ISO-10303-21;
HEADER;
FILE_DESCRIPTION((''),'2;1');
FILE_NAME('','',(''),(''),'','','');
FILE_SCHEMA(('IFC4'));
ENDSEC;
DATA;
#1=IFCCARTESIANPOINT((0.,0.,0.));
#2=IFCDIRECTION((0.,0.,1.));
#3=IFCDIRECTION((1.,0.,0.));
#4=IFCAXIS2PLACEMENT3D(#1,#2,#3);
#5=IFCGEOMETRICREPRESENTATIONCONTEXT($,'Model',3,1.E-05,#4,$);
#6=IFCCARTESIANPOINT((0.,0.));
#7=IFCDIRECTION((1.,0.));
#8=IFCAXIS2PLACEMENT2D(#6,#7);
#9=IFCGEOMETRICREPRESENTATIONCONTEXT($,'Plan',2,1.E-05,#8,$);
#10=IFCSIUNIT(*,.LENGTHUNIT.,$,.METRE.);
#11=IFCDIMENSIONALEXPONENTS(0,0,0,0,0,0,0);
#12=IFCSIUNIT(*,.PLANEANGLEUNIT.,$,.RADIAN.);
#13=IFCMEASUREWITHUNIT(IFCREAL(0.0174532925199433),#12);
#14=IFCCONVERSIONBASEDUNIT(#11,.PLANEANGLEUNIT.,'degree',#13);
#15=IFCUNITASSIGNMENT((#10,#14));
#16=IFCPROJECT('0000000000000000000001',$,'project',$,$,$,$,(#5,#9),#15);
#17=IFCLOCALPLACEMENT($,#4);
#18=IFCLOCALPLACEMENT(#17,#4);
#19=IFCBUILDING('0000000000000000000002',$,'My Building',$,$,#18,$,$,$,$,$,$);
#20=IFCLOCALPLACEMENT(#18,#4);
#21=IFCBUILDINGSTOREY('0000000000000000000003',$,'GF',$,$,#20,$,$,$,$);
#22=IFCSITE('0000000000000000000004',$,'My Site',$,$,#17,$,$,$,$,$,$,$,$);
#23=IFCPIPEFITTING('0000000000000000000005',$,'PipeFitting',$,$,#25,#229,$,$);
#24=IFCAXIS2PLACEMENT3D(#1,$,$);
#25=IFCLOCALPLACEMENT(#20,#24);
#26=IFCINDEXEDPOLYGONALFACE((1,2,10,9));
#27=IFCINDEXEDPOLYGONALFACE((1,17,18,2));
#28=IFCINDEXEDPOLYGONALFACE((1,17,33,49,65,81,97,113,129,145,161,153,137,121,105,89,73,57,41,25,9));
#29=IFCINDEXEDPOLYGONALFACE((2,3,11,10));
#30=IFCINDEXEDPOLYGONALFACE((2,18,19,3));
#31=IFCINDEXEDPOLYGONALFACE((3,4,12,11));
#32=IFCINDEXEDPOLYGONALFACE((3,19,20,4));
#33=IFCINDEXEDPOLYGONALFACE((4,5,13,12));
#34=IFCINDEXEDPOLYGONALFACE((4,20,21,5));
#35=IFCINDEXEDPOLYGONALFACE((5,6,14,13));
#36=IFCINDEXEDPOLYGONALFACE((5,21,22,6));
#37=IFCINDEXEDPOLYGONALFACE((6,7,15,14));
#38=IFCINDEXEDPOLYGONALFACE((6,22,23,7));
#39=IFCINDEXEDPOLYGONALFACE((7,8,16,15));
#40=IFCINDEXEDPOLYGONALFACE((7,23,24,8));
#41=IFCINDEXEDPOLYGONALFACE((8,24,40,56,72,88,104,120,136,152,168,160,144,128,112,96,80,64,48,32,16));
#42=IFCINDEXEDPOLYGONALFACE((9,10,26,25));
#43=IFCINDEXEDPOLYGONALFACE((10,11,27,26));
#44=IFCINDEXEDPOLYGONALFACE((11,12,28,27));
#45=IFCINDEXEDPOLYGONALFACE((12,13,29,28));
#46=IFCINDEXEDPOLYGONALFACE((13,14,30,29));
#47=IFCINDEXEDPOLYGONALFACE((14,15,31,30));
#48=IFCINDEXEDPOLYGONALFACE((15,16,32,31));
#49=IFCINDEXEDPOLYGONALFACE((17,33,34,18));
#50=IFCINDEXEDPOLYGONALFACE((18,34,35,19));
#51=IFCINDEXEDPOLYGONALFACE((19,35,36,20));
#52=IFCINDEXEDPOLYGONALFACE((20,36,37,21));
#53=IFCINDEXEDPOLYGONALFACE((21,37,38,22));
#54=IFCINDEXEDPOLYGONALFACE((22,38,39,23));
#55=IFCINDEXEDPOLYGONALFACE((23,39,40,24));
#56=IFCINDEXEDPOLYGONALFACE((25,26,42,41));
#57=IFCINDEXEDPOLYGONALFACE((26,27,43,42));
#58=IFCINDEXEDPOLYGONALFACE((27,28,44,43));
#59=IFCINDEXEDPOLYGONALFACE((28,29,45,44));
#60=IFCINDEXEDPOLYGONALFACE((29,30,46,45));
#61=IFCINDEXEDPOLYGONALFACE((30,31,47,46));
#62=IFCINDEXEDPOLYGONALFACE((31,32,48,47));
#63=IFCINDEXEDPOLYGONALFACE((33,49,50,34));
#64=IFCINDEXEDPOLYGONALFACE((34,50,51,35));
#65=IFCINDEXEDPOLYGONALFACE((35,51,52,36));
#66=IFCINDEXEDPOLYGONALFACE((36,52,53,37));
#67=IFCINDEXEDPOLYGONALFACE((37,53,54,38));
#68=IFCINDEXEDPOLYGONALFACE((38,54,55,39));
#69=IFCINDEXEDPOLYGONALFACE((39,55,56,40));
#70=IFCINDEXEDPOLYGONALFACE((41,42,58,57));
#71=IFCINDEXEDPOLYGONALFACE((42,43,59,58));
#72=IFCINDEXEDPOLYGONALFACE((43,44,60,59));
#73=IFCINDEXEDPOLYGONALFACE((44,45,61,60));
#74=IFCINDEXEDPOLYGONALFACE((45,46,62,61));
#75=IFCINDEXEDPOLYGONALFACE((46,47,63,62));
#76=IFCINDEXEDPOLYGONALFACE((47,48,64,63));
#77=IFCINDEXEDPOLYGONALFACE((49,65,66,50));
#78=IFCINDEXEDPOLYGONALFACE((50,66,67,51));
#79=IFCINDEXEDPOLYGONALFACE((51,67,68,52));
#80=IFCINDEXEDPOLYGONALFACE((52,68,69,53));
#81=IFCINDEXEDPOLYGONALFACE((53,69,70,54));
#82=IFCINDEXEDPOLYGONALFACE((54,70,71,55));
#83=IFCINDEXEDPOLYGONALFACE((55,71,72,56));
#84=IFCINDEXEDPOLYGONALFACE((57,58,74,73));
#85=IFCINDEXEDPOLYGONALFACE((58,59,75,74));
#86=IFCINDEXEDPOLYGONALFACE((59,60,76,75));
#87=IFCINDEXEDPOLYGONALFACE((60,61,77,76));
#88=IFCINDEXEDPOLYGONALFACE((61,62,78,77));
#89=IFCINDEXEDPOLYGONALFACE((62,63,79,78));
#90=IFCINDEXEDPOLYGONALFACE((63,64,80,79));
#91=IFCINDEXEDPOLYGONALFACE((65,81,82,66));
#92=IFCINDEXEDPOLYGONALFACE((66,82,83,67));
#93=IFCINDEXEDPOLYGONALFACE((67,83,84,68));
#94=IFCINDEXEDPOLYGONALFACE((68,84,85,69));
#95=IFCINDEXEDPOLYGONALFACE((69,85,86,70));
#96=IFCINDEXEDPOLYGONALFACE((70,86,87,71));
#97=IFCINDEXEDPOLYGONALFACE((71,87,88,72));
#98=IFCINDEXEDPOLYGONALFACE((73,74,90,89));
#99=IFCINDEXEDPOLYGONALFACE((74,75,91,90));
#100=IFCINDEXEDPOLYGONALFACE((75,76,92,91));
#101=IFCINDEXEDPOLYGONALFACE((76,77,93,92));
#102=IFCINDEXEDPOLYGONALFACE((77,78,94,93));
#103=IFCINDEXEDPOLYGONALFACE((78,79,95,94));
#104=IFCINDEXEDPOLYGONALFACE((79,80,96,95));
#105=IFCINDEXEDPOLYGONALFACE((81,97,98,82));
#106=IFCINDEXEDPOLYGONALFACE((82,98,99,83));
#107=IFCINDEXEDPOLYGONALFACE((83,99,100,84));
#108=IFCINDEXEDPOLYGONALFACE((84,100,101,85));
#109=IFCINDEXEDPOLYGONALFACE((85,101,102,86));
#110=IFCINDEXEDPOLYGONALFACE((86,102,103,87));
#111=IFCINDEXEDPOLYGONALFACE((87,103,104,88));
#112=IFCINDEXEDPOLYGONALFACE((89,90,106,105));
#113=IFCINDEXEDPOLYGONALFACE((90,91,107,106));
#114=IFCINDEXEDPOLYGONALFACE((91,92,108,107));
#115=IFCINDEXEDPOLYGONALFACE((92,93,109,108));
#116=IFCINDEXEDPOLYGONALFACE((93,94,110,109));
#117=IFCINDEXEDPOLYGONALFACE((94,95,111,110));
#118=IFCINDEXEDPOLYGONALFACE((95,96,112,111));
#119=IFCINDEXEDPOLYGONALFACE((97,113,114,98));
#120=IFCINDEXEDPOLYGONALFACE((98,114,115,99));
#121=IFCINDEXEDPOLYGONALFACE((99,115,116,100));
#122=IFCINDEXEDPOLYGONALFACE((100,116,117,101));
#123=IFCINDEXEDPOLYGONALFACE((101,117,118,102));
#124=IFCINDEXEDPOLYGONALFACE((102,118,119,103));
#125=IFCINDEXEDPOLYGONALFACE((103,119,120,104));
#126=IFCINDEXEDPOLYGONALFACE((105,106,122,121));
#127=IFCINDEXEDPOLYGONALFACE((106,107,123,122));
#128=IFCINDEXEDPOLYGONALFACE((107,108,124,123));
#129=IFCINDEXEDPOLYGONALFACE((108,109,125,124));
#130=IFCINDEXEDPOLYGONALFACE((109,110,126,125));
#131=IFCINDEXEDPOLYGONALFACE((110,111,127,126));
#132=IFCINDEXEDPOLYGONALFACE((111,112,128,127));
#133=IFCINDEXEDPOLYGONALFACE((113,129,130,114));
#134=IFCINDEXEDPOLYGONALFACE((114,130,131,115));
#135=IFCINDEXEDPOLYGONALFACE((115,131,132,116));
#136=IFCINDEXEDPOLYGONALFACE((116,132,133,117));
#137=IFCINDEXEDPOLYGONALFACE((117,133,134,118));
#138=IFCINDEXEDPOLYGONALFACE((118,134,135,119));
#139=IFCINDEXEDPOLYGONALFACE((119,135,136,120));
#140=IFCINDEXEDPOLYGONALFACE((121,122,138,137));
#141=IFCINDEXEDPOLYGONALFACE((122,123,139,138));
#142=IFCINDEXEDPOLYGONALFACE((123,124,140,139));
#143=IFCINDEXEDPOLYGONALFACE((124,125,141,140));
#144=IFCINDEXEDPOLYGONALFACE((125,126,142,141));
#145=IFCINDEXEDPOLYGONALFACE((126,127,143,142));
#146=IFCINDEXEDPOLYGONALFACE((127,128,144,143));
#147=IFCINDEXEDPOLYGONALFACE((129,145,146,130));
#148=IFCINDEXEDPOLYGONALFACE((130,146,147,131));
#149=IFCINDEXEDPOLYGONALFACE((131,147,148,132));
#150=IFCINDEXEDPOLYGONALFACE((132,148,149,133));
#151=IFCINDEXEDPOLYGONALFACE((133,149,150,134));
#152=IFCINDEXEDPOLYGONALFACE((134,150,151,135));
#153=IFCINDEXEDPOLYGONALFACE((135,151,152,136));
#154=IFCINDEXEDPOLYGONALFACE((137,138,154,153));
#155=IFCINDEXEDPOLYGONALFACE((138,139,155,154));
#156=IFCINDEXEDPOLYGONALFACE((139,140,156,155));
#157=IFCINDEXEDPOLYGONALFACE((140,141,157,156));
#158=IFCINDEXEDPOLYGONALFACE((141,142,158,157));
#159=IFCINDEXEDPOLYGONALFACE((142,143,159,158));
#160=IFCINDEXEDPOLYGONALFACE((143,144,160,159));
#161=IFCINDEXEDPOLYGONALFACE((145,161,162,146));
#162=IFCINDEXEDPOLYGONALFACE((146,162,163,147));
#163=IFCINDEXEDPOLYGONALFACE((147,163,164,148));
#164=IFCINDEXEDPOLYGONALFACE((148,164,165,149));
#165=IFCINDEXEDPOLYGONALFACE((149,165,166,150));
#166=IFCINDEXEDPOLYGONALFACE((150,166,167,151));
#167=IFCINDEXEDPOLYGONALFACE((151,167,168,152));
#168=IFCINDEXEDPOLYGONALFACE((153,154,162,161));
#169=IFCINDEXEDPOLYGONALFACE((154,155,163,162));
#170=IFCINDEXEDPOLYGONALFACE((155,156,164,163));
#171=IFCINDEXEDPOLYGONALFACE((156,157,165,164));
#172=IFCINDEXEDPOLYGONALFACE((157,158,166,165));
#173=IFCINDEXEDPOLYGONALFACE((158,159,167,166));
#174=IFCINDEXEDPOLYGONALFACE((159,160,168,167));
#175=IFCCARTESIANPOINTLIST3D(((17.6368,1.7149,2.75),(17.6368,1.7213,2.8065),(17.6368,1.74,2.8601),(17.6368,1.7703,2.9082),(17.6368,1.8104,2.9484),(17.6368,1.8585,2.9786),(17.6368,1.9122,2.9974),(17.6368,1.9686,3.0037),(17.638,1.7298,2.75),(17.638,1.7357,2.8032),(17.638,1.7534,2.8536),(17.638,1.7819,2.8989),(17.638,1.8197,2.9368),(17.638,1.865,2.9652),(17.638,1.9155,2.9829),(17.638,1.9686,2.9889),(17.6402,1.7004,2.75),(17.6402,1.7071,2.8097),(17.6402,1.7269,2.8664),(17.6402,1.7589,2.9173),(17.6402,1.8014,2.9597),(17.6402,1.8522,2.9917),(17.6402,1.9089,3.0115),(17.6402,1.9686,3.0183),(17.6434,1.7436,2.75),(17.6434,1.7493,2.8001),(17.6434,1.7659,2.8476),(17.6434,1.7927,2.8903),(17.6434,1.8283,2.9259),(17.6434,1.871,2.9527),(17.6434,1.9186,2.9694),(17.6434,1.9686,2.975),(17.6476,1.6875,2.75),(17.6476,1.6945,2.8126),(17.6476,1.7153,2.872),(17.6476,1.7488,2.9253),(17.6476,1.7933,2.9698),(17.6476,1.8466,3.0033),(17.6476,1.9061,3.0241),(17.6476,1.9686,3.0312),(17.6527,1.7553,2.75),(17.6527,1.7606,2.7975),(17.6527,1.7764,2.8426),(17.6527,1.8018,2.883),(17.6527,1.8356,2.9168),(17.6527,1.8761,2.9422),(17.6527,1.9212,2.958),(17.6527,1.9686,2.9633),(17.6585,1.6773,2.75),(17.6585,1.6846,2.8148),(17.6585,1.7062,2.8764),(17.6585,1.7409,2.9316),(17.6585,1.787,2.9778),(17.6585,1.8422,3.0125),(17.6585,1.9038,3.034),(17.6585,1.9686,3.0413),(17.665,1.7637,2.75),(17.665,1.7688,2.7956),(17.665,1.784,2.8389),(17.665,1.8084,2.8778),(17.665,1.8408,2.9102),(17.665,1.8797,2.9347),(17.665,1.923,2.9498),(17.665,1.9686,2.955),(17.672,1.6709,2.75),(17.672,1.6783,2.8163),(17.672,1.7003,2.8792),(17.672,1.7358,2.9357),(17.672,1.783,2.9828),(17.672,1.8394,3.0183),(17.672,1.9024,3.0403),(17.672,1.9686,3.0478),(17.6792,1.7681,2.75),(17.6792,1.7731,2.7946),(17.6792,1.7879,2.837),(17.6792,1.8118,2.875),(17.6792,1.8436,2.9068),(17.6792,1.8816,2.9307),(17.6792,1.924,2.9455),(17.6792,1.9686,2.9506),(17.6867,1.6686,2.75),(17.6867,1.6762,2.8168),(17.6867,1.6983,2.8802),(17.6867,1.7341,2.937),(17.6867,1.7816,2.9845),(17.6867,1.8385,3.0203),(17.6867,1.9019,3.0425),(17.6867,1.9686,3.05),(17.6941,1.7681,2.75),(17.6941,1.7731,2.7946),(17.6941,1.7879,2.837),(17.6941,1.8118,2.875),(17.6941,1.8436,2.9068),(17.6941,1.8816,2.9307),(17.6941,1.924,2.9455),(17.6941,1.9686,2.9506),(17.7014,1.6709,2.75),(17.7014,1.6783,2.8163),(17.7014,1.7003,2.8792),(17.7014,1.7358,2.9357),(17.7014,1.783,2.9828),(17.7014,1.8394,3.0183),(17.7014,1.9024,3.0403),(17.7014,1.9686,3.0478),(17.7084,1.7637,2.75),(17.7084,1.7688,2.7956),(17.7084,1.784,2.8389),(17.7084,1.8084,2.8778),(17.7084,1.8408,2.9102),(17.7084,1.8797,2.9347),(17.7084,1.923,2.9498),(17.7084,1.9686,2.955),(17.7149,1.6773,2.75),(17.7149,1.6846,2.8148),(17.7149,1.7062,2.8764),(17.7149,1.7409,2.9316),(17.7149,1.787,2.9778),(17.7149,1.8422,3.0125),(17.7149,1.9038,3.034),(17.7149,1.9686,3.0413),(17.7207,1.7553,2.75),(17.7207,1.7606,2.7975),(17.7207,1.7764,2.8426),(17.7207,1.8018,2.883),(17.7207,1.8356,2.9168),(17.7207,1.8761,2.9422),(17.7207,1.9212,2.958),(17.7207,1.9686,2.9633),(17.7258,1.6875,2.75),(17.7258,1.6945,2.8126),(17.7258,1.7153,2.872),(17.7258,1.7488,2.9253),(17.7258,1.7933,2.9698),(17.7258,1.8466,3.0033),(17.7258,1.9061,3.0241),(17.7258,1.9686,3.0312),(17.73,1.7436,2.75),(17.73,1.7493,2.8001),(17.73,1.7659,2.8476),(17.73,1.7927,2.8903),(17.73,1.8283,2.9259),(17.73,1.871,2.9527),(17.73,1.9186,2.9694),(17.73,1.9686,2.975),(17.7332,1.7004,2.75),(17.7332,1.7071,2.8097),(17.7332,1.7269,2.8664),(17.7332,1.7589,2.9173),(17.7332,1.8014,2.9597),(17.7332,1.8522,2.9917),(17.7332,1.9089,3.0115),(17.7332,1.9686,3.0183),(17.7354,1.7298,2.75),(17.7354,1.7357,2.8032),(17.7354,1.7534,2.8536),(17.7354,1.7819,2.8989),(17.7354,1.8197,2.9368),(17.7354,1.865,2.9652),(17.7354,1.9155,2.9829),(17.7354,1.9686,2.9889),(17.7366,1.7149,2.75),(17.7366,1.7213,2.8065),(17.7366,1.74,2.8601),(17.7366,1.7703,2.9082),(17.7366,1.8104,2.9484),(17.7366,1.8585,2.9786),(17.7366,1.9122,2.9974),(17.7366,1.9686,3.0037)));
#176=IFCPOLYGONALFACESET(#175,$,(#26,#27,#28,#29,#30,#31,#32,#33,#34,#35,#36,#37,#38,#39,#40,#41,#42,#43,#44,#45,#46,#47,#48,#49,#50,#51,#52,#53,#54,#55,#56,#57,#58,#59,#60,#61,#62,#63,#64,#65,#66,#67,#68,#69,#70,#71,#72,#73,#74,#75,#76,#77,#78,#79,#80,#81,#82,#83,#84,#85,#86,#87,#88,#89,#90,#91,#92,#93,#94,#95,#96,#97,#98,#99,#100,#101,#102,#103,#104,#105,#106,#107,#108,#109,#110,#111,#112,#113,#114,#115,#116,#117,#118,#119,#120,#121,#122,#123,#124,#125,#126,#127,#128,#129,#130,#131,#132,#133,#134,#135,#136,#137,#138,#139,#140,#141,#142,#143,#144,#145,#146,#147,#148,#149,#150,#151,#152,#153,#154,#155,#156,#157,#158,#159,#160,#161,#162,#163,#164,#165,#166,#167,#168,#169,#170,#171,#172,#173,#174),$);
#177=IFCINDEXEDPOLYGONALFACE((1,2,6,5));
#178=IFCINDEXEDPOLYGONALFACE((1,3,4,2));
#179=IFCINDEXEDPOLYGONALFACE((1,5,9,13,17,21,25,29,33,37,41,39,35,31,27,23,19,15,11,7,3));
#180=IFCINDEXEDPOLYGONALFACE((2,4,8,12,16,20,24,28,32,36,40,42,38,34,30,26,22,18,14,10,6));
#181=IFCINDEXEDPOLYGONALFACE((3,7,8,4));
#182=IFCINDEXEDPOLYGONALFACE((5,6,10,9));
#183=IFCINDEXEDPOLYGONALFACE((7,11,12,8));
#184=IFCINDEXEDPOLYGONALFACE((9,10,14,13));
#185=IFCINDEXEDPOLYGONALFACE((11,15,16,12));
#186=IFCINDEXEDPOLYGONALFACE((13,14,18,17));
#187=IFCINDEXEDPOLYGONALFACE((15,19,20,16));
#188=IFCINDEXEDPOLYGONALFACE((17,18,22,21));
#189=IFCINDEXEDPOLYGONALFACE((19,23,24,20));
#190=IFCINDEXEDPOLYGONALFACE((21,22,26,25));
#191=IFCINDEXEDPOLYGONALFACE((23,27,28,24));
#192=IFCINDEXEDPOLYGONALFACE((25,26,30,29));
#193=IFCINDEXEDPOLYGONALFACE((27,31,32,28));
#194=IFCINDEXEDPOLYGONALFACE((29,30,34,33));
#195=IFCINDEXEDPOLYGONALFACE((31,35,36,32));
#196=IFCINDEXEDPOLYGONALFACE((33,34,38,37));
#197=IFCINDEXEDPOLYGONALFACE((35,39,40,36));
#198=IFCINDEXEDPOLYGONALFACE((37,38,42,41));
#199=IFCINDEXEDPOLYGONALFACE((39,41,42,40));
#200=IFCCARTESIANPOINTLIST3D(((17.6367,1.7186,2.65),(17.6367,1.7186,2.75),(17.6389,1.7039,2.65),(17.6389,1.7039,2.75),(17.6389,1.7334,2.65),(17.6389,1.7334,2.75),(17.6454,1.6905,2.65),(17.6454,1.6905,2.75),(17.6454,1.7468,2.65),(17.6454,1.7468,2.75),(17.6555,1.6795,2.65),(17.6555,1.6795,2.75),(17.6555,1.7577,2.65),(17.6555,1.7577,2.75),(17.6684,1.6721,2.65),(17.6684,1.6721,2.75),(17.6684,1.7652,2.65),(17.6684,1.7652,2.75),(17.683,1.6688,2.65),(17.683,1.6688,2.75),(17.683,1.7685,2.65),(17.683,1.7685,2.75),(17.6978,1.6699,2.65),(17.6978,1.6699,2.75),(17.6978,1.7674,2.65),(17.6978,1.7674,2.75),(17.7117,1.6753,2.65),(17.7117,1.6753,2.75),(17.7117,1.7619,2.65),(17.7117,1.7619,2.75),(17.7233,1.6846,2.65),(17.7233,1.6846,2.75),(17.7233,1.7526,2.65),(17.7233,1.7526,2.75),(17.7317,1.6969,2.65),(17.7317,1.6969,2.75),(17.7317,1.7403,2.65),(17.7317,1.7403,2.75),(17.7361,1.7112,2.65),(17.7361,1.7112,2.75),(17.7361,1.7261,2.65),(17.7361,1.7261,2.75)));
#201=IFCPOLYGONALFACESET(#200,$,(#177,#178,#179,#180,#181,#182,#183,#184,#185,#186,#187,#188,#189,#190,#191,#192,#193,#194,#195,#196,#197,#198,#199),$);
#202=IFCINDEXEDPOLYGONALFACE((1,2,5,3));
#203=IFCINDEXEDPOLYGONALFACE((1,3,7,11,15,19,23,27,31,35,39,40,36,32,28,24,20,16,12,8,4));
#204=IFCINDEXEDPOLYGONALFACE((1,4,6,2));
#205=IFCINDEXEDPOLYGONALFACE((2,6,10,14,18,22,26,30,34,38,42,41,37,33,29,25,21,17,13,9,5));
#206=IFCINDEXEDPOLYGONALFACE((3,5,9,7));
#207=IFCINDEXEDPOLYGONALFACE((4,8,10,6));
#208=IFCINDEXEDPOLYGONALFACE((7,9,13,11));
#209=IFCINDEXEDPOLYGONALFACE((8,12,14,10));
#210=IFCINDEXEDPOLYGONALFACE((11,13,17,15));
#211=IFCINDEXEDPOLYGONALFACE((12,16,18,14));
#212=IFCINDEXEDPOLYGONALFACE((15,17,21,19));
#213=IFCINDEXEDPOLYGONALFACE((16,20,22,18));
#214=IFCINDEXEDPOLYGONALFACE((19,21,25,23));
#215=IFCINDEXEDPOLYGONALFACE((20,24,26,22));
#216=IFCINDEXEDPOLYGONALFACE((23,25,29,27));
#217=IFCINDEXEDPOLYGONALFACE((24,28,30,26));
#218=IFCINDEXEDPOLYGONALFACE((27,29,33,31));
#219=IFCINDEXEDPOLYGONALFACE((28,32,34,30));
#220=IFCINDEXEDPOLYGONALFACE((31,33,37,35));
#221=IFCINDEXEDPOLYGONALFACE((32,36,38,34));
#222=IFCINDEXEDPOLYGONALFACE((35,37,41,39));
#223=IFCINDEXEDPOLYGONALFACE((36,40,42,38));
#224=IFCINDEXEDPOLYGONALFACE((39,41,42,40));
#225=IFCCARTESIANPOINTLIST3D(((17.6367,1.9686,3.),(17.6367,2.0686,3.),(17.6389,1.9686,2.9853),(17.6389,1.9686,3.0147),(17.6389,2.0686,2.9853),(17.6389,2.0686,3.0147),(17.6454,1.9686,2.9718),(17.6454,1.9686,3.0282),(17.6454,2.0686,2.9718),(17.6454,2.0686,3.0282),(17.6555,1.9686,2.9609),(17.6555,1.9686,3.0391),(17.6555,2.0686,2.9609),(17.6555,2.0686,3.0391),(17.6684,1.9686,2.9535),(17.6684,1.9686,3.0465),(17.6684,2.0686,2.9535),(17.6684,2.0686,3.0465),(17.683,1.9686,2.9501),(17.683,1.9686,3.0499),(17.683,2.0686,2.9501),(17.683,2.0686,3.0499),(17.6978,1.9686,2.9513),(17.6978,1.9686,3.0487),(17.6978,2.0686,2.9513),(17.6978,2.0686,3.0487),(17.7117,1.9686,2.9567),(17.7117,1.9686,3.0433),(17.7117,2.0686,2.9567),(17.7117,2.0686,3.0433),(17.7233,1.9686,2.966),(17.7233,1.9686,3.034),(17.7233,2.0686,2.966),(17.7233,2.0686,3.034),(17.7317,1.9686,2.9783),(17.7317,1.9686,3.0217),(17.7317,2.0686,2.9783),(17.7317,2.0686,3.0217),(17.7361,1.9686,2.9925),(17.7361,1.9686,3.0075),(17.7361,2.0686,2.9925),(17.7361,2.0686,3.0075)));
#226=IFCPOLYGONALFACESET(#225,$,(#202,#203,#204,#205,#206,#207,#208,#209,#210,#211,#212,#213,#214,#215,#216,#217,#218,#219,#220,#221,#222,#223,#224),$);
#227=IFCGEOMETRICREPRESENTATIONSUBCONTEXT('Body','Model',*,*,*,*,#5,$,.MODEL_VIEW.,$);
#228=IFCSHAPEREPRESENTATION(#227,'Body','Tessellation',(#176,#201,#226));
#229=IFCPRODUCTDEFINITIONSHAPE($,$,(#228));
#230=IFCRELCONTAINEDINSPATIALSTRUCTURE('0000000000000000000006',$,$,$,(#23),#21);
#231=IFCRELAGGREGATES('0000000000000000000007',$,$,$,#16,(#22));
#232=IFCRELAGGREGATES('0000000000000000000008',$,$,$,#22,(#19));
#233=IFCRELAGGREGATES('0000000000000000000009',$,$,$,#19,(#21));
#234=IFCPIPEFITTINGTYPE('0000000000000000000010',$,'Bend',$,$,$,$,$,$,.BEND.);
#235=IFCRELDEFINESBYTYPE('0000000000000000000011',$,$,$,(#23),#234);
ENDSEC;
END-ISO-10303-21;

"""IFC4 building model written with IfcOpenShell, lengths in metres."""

from ifc_helpers import new_model, entity, si_unit, converted_unit, frame, origin_with_axes, origin_2d_with_axis, place, context, subcontext, project, spatial, circle, extrude, source, transform, mapped, type_object, type_shapes, element, save


model = new_model("IFC4")

# Units and contexts
model_context = context("Model", 3, precision=1e-05, world=origin_with_axes())
plan_context = context("Plan", 2, precision=1e-05, world=origin_2d_with_axis())
body_context_1 = subcontext(model_context, "Body", "Model", "MODEL_VIEW")
ifc_project = project(units=[si_unit("LENGTHUNIT", "METRE"), converted_unit("PLANEANGLEUNIT", "degree", entity("IfcReal", 0.0174532925199433), si_unit("PLANEANGLEUNIT", "RADIAN"), dimensions=[0, 0, 0, 0, 0, 0, 0])], contexts=[model_context, plan_context])

# Site, building, storey
site_placement = place(None, origin_with_axes())
site = spatial("IfcSite", under=ifc_project, at=site_placement, Name="My Site")
building_placement = place(site_placement, origin_with_axes())
building = spatial("IfcBuilding", under=site, at=building_placement, Name="My Building")
storey_placement = place(building_placement, origin_with_axes())
storey = spatial("IfcBuildingStorey", under=building, at=storey_placement, Name="GF")

# Pipe fitting
pipe_fitting_type = type_object("IfcPipeFittingType", Name="Bend", PredefinedType="BEND")
shared_shape_1 = source(origin_with_axes(), body_context_1, "Body", "SolidModel", [
    entity("IfcSweptDiskSolid", entity("IfcIndexedPolyCurve", entity("IfcCartesianPointList3D", [[0.0, 0.0, -0.1], [0.0, 0.0732, -0.2768], [0.0, 0.25, -0.35]]), [entity("IfcArcIndex", [1, 2, 3])]), 0.05),
    extrude(circle(Radius=0.05), origin_with_axes(), (0.0, 0.0, -1.0), 0.1),
    extrude(circle(Radius=0.05), frame((0.0, 0.25, -0.35), z_axis=(0.0, 1.0, 0.0), x_axis=(1.0, 0.0, 0.0)), (0.0, 0.0, 1.0), 0.1),
])
type_shapes(pipe_fitting_type, [shared_shape_1])
for number, where, z_axis, x_axis, name in (
    (1, (17.6867, 1.7186, 2.65), (0.0, 0.0, -1.0), (-1.0, 0.0, 0.0), "PipeFitting"),
):
    element("IfcPipeFitting", number, at=place(storey_placement, frame(where, z_axis=z_axis, x_axis=x_axis)), inside=storey, type_object=pipe_fitting_type, Name=name, context=body_context_1, shape_type="MappedRepresentation", body=[
        mapped(shared_shape_1, transform((0.0, 0.0, 0.0), x_axis=(1.0, 0.0, 0.0), y_axis=(0.0, 1.0, 0.0), z_axis=(0.0, 0.0, 1.0), scale=1.0)),
    ])

save(model, "model.ifc")
